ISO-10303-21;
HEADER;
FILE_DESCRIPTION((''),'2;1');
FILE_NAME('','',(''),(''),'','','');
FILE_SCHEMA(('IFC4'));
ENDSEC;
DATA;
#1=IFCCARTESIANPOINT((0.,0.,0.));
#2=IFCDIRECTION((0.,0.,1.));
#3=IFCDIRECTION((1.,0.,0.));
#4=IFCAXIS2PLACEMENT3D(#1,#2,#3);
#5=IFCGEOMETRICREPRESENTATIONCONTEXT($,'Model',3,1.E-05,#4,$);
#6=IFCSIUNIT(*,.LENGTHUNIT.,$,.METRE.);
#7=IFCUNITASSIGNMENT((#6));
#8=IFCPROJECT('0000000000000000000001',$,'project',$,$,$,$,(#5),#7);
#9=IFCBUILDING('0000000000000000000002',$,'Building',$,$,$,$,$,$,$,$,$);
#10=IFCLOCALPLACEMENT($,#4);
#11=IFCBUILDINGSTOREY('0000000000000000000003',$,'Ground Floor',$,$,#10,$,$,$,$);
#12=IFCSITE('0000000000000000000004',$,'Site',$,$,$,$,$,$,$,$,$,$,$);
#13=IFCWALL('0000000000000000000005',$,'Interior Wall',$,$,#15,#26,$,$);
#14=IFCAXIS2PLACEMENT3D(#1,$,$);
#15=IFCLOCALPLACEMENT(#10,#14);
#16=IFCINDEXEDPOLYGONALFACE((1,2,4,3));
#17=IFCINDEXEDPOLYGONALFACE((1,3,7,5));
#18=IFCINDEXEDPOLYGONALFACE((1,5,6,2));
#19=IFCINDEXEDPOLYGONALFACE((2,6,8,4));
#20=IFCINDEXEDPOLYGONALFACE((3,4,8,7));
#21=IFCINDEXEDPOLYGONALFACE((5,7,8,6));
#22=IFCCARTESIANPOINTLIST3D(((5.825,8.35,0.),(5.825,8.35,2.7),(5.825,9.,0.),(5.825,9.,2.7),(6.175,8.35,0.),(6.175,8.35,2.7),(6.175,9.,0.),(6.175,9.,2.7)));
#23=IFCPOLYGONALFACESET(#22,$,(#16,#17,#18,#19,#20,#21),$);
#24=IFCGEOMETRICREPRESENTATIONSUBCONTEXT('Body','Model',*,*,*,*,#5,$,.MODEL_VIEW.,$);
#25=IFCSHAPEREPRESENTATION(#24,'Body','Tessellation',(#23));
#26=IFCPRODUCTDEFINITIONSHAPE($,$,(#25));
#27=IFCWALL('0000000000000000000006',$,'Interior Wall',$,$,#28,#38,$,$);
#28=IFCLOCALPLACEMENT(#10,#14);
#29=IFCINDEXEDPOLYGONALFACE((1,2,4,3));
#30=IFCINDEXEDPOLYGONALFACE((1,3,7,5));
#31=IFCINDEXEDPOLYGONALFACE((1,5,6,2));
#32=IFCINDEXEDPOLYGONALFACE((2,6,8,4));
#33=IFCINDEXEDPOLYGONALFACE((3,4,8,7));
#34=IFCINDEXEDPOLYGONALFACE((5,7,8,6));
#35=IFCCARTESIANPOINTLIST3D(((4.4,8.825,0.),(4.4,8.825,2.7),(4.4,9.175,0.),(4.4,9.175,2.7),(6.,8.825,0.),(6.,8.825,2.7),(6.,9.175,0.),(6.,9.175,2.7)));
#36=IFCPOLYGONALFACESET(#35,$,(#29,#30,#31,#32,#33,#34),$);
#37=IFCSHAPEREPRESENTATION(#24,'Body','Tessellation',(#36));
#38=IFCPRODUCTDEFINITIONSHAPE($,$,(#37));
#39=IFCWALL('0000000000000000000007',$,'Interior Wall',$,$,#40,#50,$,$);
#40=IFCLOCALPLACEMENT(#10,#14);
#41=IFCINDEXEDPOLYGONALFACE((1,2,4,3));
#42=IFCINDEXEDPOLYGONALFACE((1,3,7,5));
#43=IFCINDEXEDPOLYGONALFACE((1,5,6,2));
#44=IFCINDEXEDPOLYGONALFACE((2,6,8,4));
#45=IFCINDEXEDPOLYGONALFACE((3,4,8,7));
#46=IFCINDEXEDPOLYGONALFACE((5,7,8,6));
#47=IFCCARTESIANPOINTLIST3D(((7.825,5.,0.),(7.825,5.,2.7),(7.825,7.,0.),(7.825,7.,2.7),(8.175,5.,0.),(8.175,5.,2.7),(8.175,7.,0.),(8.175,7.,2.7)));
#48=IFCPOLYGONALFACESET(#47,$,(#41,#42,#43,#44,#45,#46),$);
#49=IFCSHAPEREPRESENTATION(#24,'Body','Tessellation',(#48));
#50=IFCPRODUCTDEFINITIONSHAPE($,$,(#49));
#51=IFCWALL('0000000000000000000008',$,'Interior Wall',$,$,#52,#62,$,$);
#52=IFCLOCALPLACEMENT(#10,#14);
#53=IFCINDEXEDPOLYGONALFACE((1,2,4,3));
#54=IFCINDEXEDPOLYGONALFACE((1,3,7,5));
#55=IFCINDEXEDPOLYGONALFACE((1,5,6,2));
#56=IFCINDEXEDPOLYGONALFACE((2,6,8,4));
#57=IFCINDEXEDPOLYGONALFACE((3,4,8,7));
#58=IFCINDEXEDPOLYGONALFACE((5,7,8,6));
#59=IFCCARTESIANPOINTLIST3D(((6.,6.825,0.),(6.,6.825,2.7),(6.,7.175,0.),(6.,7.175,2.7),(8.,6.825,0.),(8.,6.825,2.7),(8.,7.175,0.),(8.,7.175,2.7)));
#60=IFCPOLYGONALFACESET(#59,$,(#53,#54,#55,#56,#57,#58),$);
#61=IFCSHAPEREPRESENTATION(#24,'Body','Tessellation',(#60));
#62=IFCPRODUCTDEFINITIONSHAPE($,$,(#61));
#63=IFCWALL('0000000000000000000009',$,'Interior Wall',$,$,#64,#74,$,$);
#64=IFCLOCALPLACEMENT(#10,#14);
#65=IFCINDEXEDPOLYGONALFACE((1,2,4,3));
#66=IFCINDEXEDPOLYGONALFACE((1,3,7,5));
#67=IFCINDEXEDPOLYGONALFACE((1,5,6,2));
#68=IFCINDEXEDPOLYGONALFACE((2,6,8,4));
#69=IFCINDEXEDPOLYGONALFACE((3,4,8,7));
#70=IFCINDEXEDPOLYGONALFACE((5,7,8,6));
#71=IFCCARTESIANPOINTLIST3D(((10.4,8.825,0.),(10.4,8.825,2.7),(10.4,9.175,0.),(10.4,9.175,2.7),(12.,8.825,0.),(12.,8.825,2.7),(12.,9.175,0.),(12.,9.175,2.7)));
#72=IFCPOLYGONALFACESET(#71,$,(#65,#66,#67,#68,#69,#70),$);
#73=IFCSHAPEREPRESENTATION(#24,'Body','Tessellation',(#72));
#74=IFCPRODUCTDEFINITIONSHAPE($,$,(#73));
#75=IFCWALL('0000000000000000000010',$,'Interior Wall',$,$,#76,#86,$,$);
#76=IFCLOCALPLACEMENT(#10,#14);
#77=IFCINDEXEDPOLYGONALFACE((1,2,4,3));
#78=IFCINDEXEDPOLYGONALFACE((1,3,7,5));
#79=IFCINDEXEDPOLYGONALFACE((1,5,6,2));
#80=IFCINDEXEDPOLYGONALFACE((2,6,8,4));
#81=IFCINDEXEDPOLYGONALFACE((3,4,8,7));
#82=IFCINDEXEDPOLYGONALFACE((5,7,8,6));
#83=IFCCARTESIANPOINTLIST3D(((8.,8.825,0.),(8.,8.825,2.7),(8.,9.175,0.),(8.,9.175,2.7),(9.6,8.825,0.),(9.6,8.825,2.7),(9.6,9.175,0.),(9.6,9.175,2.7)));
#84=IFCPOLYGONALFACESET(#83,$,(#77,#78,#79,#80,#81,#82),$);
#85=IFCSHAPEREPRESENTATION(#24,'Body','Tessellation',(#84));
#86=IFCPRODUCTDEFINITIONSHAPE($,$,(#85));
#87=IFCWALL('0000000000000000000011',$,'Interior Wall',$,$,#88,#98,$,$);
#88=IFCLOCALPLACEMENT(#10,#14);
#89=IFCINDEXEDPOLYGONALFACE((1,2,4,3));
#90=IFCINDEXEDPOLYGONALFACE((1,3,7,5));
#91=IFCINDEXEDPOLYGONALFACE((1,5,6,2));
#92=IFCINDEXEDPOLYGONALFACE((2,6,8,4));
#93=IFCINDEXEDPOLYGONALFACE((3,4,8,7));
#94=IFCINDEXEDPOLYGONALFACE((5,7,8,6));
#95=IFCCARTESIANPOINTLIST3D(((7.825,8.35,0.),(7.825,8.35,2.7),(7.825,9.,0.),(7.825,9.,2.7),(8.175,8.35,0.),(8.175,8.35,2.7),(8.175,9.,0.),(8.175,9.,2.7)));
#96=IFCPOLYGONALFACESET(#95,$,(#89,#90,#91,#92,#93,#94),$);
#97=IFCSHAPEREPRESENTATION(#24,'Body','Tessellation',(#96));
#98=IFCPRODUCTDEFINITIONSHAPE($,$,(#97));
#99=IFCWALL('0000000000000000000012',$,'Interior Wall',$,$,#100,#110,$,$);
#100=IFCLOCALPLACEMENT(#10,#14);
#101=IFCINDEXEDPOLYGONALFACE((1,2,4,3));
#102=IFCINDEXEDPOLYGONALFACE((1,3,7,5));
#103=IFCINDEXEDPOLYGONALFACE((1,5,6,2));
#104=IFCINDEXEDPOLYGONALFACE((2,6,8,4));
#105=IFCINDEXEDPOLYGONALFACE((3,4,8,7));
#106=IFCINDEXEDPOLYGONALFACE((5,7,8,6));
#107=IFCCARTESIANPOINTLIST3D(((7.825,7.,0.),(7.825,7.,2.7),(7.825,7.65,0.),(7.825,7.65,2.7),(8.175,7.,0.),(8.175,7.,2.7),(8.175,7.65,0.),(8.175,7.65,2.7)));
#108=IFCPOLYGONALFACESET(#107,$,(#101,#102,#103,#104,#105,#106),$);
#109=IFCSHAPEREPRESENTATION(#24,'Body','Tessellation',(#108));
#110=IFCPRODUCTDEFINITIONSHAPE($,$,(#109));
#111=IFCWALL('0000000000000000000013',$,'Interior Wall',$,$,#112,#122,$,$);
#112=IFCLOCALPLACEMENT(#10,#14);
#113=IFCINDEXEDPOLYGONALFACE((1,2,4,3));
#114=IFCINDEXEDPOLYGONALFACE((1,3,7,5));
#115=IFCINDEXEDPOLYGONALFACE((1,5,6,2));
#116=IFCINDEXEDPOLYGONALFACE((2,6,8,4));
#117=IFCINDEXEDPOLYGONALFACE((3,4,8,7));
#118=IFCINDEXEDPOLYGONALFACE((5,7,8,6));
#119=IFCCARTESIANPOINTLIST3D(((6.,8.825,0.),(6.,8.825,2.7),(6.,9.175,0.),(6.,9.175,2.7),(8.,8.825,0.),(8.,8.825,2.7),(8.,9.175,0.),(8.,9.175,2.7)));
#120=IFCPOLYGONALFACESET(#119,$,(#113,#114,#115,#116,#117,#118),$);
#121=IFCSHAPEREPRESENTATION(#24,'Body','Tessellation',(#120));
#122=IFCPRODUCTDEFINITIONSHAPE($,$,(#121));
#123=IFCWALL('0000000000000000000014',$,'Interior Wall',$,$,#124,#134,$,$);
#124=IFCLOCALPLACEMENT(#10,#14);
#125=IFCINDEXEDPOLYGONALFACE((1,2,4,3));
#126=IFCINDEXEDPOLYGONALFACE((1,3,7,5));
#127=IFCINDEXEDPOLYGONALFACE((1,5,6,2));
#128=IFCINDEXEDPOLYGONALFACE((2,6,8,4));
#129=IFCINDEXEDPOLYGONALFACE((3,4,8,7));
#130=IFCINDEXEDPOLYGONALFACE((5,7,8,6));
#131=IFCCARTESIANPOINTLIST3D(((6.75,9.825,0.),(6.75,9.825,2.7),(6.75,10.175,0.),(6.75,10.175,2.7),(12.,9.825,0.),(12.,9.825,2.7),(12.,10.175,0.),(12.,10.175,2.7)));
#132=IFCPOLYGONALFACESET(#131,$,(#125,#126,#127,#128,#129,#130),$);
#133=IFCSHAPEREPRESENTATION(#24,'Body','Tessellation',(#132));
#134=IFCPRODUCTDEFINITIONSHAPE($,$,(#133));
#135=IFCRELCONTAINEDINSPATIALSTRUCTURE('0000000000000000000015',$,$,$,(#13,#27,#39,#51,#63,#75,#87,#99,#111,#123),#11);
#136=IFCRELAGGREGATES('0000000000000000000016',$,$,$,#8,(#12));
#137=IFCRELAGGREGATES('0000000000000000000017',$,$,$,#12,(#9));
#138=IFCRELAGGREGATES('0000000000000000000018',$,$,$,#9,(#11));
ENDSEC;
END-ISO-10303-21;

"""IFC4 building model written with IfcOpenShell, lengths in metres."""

from ifc_helpers import new_model, si_unit, frame, origin_with_axes, place, context, subcontext, project, spatial, indexed_curve, outline, extrude, element, save


model = new_model("IFC4")

# Units and contexts
model_context = context("Model", 3, precision=1e-05, world=origin_with_axes())
body_context = subcontext(model_context, "Body", "Model", "MODEL_VIEW")
ifc_project = project(units=[si_unit("LENGTHUNIT", "METRE")], contexts=[model_context])

# Site, building, storey
site = spatial("IfcSite", under=ifc_project, Name="Site")
building = spatial("IfcBuilding", under=site, Name="Building")
storey_placement = place(None, origin_with_axes())
storey = spatial("IfcBuildingStorey", under=building, at=storey_placement, Name="Ground Floor")

# Walls
for number, where, z_axis, x_axis, name in (
    (1, (6.0, 8.35, 0.0), (0.0, 0.0, 1.0), (0.0, 1.0, 0.0), "Interior Wall"),
):
    element("IfcWall", number, at=place(storey_placement, frame(where, z_axis=z_axis, x_axis=x_axis)), inside=storey, Name=name, context=body_context, shape_type="SweptSolid", body=[
        extrude(outline(indexed_curve([(0.0, 0.0), (0.0, 0.35), (0.65, 0.35), (0.65, 0.0), (0.0, 0.0)], self_intersect=False)), frame((0.0, -0.175, 0.0), z_axis=(0.0, 0.0, 1.0), x_axis=(1.0, 0.0, 0.0)), (0.0, 0.0, 1.0), 2.7),
    ])
wall_1_placement = place(storey_placement, frame((6.0, 9.0, 0.0), z_axis=(0.0, 0.0, 1.0), x_axis=(-1.0, 0.0, 0.0)))
element("IfcWall", 2, at=wall_1_placement, inside=storey, Name="Interior Wall", context=body_context, shape_type="SweptSolid", body=[
    extrude(outline(indexed_curve([(0.0, 0.0), (0.0, 0.35), (1.6, 0.35), (1.6, 0.0), (0.0, 0.0)], self_intersect=False)), frame((0.0, -0.175, 0.0), z_axis=(0.0, 0.0, 1.0), x_axis=(1.0, 0.0, 0.0)), (0.0, 0.0, 1.0), 2.7),
])
for number, where, z_axis, x_axis, name in (
    (3, (8.0, 5.0, 0.0), (0.0, 0.0, 1.0), (0.0, 1.0, 0.0), "Interior Wall"),
    (4, (8.0, 7.0, 0.0), (0.0, 0.0, 1.0), (-1.0, 0.0, 0.0), "Interior Wall"),
):
    element("IfcWall", number, at=place(storey_placement, frame(where, z_axis=z_axis, x_axis=x_axis)), inside=storey, Name=name, context=body_context, shape_type="SweptSolid", body=[
        extrude(outline(indexed_curve([(0.0, 0.0), (0.0, 0.35), (2.0, 0.35), (2.0, 0.0), (0.0, 0.0)], self_intersect=False)), frame((0.0, -0.175, 0.0), z_axis=(0.0, 0.0, 1.0), x_axis=(1.0, 0.0, 0.0)), (0.0, 0.0, 1.0), 2.7),
    ])
for number, where, z_axis, x_axis, name in (
    (5, (12.0, 9.0, 0.0), (0.0, 0.0, 1.0), (-1.0, 0.0, 0.0), "Interior Wall"),
    (6, (9.6, 9.0, 0.0), (0.0, 0.0, 1.0), (-1.0, 0.0, 0.0), "Interior Wall"),
):
    element("IfcWall", number, at=place(storey_placement, frame(where, z_axis=z_axis, x_axis=x_axis)), inside=storey, Name=name, context=body_context, shape_type="SweptSolid", body=[
        extrude(outline(indexed_curve([(0.0, 0.0), (0.0, 0.35), (1.6, 0.35), (1.6, 0.0), (0.0, 0.0)], self_intersect=False)), frame((0.0, -0.175, 0.0), z_axis=(0.0, 0.0, 1.0), x_axis=(1.0, 0.0, 0.0)), (0.0, 0.0, 1.0), 2.7),
    ])
for number, where, z_axis, x_axis, name in (
    (7, (8.0, 9.0, 0.0), (0.0, 0.0, 1.0), (0.0, -1.0, 0.0), "Interior Wall"),
    (8, (8.0, 7.65, 0.0), (0.0, 0.0, 1.0), (0.0, -1.0, 0.0), "Interior Wall"),
):
    element("IfcWall", number, at=place(storey_placement, frame(where, z_axis=z_axis, x_axis=x_axis)), inside=storey, Name=name, context=body_context, shape_type="SweptSolid", body=[
        extrude(outline(indexed_curve([(0.0, 0.0), (0.0, 0.35), (0.65, 0.35), (0.65, 0.0), (0.0, 0.0)], self_intersect=False)), frame((0.0, -0.175, 0.0), z_axis=(0.0, 0.0, 1.0), x_axis=(1.0, 0.0, 0.0)), (0.0, 0.0, 1.0), 2.7),
    ])
wall_2_placement = place(storey_placement, frame((8.0, 9.0, 0.0), z_axis=(0.0, 0.0, 1.0), x_axis=(-1.0, 0.0, 0.0)))
element("IfcWall", 9, at=wall_2_placement, inside=storey, Name="Interior Wall", context=body_context, shape_type="SweptSolid", body=[
    extrude(outline(indexed_curve([(0.0, 0.0), (0.0, 0.35), (2.0, 0.35), (2.0, 0.0), (0.0, 0.0)], self_intersect=False)), frame((0.0, -0.175, 0.0), z_axis=(0.0, 0.0, 1.0), x_axis=(1.0, 0.0, 0.0)), (0.0, 0.0, 1.0), 2.7),
])
wall_3_placement = place(storey_placement, frame((12.0, 10.0, 0.0), z_axis=(0.0, 0.0, 1.0), x_axis=(-1.0, 0.0, 0.0)))
element("IfcWall", 10, at=wall_3_placement, inside=storey, Name="Interior Wall", context=body_context, shape_type="SweptSolid", body=[
    extrude(outline(indexed_curve([(0.0, 0.0), (0.0, 0.35), (5.25, 0.35), (5.25, 0.0), (0.0, 0.0)], self_intersect=False)), frame((0.0, -0.175, 0.0), z_axis=(0.0, 0.0, 1.0), x_axis=(1.0, 0.0, 0.0)), (0.0, 0.0, 1.0), 2.7),
])

save(model, "model.ifc")
